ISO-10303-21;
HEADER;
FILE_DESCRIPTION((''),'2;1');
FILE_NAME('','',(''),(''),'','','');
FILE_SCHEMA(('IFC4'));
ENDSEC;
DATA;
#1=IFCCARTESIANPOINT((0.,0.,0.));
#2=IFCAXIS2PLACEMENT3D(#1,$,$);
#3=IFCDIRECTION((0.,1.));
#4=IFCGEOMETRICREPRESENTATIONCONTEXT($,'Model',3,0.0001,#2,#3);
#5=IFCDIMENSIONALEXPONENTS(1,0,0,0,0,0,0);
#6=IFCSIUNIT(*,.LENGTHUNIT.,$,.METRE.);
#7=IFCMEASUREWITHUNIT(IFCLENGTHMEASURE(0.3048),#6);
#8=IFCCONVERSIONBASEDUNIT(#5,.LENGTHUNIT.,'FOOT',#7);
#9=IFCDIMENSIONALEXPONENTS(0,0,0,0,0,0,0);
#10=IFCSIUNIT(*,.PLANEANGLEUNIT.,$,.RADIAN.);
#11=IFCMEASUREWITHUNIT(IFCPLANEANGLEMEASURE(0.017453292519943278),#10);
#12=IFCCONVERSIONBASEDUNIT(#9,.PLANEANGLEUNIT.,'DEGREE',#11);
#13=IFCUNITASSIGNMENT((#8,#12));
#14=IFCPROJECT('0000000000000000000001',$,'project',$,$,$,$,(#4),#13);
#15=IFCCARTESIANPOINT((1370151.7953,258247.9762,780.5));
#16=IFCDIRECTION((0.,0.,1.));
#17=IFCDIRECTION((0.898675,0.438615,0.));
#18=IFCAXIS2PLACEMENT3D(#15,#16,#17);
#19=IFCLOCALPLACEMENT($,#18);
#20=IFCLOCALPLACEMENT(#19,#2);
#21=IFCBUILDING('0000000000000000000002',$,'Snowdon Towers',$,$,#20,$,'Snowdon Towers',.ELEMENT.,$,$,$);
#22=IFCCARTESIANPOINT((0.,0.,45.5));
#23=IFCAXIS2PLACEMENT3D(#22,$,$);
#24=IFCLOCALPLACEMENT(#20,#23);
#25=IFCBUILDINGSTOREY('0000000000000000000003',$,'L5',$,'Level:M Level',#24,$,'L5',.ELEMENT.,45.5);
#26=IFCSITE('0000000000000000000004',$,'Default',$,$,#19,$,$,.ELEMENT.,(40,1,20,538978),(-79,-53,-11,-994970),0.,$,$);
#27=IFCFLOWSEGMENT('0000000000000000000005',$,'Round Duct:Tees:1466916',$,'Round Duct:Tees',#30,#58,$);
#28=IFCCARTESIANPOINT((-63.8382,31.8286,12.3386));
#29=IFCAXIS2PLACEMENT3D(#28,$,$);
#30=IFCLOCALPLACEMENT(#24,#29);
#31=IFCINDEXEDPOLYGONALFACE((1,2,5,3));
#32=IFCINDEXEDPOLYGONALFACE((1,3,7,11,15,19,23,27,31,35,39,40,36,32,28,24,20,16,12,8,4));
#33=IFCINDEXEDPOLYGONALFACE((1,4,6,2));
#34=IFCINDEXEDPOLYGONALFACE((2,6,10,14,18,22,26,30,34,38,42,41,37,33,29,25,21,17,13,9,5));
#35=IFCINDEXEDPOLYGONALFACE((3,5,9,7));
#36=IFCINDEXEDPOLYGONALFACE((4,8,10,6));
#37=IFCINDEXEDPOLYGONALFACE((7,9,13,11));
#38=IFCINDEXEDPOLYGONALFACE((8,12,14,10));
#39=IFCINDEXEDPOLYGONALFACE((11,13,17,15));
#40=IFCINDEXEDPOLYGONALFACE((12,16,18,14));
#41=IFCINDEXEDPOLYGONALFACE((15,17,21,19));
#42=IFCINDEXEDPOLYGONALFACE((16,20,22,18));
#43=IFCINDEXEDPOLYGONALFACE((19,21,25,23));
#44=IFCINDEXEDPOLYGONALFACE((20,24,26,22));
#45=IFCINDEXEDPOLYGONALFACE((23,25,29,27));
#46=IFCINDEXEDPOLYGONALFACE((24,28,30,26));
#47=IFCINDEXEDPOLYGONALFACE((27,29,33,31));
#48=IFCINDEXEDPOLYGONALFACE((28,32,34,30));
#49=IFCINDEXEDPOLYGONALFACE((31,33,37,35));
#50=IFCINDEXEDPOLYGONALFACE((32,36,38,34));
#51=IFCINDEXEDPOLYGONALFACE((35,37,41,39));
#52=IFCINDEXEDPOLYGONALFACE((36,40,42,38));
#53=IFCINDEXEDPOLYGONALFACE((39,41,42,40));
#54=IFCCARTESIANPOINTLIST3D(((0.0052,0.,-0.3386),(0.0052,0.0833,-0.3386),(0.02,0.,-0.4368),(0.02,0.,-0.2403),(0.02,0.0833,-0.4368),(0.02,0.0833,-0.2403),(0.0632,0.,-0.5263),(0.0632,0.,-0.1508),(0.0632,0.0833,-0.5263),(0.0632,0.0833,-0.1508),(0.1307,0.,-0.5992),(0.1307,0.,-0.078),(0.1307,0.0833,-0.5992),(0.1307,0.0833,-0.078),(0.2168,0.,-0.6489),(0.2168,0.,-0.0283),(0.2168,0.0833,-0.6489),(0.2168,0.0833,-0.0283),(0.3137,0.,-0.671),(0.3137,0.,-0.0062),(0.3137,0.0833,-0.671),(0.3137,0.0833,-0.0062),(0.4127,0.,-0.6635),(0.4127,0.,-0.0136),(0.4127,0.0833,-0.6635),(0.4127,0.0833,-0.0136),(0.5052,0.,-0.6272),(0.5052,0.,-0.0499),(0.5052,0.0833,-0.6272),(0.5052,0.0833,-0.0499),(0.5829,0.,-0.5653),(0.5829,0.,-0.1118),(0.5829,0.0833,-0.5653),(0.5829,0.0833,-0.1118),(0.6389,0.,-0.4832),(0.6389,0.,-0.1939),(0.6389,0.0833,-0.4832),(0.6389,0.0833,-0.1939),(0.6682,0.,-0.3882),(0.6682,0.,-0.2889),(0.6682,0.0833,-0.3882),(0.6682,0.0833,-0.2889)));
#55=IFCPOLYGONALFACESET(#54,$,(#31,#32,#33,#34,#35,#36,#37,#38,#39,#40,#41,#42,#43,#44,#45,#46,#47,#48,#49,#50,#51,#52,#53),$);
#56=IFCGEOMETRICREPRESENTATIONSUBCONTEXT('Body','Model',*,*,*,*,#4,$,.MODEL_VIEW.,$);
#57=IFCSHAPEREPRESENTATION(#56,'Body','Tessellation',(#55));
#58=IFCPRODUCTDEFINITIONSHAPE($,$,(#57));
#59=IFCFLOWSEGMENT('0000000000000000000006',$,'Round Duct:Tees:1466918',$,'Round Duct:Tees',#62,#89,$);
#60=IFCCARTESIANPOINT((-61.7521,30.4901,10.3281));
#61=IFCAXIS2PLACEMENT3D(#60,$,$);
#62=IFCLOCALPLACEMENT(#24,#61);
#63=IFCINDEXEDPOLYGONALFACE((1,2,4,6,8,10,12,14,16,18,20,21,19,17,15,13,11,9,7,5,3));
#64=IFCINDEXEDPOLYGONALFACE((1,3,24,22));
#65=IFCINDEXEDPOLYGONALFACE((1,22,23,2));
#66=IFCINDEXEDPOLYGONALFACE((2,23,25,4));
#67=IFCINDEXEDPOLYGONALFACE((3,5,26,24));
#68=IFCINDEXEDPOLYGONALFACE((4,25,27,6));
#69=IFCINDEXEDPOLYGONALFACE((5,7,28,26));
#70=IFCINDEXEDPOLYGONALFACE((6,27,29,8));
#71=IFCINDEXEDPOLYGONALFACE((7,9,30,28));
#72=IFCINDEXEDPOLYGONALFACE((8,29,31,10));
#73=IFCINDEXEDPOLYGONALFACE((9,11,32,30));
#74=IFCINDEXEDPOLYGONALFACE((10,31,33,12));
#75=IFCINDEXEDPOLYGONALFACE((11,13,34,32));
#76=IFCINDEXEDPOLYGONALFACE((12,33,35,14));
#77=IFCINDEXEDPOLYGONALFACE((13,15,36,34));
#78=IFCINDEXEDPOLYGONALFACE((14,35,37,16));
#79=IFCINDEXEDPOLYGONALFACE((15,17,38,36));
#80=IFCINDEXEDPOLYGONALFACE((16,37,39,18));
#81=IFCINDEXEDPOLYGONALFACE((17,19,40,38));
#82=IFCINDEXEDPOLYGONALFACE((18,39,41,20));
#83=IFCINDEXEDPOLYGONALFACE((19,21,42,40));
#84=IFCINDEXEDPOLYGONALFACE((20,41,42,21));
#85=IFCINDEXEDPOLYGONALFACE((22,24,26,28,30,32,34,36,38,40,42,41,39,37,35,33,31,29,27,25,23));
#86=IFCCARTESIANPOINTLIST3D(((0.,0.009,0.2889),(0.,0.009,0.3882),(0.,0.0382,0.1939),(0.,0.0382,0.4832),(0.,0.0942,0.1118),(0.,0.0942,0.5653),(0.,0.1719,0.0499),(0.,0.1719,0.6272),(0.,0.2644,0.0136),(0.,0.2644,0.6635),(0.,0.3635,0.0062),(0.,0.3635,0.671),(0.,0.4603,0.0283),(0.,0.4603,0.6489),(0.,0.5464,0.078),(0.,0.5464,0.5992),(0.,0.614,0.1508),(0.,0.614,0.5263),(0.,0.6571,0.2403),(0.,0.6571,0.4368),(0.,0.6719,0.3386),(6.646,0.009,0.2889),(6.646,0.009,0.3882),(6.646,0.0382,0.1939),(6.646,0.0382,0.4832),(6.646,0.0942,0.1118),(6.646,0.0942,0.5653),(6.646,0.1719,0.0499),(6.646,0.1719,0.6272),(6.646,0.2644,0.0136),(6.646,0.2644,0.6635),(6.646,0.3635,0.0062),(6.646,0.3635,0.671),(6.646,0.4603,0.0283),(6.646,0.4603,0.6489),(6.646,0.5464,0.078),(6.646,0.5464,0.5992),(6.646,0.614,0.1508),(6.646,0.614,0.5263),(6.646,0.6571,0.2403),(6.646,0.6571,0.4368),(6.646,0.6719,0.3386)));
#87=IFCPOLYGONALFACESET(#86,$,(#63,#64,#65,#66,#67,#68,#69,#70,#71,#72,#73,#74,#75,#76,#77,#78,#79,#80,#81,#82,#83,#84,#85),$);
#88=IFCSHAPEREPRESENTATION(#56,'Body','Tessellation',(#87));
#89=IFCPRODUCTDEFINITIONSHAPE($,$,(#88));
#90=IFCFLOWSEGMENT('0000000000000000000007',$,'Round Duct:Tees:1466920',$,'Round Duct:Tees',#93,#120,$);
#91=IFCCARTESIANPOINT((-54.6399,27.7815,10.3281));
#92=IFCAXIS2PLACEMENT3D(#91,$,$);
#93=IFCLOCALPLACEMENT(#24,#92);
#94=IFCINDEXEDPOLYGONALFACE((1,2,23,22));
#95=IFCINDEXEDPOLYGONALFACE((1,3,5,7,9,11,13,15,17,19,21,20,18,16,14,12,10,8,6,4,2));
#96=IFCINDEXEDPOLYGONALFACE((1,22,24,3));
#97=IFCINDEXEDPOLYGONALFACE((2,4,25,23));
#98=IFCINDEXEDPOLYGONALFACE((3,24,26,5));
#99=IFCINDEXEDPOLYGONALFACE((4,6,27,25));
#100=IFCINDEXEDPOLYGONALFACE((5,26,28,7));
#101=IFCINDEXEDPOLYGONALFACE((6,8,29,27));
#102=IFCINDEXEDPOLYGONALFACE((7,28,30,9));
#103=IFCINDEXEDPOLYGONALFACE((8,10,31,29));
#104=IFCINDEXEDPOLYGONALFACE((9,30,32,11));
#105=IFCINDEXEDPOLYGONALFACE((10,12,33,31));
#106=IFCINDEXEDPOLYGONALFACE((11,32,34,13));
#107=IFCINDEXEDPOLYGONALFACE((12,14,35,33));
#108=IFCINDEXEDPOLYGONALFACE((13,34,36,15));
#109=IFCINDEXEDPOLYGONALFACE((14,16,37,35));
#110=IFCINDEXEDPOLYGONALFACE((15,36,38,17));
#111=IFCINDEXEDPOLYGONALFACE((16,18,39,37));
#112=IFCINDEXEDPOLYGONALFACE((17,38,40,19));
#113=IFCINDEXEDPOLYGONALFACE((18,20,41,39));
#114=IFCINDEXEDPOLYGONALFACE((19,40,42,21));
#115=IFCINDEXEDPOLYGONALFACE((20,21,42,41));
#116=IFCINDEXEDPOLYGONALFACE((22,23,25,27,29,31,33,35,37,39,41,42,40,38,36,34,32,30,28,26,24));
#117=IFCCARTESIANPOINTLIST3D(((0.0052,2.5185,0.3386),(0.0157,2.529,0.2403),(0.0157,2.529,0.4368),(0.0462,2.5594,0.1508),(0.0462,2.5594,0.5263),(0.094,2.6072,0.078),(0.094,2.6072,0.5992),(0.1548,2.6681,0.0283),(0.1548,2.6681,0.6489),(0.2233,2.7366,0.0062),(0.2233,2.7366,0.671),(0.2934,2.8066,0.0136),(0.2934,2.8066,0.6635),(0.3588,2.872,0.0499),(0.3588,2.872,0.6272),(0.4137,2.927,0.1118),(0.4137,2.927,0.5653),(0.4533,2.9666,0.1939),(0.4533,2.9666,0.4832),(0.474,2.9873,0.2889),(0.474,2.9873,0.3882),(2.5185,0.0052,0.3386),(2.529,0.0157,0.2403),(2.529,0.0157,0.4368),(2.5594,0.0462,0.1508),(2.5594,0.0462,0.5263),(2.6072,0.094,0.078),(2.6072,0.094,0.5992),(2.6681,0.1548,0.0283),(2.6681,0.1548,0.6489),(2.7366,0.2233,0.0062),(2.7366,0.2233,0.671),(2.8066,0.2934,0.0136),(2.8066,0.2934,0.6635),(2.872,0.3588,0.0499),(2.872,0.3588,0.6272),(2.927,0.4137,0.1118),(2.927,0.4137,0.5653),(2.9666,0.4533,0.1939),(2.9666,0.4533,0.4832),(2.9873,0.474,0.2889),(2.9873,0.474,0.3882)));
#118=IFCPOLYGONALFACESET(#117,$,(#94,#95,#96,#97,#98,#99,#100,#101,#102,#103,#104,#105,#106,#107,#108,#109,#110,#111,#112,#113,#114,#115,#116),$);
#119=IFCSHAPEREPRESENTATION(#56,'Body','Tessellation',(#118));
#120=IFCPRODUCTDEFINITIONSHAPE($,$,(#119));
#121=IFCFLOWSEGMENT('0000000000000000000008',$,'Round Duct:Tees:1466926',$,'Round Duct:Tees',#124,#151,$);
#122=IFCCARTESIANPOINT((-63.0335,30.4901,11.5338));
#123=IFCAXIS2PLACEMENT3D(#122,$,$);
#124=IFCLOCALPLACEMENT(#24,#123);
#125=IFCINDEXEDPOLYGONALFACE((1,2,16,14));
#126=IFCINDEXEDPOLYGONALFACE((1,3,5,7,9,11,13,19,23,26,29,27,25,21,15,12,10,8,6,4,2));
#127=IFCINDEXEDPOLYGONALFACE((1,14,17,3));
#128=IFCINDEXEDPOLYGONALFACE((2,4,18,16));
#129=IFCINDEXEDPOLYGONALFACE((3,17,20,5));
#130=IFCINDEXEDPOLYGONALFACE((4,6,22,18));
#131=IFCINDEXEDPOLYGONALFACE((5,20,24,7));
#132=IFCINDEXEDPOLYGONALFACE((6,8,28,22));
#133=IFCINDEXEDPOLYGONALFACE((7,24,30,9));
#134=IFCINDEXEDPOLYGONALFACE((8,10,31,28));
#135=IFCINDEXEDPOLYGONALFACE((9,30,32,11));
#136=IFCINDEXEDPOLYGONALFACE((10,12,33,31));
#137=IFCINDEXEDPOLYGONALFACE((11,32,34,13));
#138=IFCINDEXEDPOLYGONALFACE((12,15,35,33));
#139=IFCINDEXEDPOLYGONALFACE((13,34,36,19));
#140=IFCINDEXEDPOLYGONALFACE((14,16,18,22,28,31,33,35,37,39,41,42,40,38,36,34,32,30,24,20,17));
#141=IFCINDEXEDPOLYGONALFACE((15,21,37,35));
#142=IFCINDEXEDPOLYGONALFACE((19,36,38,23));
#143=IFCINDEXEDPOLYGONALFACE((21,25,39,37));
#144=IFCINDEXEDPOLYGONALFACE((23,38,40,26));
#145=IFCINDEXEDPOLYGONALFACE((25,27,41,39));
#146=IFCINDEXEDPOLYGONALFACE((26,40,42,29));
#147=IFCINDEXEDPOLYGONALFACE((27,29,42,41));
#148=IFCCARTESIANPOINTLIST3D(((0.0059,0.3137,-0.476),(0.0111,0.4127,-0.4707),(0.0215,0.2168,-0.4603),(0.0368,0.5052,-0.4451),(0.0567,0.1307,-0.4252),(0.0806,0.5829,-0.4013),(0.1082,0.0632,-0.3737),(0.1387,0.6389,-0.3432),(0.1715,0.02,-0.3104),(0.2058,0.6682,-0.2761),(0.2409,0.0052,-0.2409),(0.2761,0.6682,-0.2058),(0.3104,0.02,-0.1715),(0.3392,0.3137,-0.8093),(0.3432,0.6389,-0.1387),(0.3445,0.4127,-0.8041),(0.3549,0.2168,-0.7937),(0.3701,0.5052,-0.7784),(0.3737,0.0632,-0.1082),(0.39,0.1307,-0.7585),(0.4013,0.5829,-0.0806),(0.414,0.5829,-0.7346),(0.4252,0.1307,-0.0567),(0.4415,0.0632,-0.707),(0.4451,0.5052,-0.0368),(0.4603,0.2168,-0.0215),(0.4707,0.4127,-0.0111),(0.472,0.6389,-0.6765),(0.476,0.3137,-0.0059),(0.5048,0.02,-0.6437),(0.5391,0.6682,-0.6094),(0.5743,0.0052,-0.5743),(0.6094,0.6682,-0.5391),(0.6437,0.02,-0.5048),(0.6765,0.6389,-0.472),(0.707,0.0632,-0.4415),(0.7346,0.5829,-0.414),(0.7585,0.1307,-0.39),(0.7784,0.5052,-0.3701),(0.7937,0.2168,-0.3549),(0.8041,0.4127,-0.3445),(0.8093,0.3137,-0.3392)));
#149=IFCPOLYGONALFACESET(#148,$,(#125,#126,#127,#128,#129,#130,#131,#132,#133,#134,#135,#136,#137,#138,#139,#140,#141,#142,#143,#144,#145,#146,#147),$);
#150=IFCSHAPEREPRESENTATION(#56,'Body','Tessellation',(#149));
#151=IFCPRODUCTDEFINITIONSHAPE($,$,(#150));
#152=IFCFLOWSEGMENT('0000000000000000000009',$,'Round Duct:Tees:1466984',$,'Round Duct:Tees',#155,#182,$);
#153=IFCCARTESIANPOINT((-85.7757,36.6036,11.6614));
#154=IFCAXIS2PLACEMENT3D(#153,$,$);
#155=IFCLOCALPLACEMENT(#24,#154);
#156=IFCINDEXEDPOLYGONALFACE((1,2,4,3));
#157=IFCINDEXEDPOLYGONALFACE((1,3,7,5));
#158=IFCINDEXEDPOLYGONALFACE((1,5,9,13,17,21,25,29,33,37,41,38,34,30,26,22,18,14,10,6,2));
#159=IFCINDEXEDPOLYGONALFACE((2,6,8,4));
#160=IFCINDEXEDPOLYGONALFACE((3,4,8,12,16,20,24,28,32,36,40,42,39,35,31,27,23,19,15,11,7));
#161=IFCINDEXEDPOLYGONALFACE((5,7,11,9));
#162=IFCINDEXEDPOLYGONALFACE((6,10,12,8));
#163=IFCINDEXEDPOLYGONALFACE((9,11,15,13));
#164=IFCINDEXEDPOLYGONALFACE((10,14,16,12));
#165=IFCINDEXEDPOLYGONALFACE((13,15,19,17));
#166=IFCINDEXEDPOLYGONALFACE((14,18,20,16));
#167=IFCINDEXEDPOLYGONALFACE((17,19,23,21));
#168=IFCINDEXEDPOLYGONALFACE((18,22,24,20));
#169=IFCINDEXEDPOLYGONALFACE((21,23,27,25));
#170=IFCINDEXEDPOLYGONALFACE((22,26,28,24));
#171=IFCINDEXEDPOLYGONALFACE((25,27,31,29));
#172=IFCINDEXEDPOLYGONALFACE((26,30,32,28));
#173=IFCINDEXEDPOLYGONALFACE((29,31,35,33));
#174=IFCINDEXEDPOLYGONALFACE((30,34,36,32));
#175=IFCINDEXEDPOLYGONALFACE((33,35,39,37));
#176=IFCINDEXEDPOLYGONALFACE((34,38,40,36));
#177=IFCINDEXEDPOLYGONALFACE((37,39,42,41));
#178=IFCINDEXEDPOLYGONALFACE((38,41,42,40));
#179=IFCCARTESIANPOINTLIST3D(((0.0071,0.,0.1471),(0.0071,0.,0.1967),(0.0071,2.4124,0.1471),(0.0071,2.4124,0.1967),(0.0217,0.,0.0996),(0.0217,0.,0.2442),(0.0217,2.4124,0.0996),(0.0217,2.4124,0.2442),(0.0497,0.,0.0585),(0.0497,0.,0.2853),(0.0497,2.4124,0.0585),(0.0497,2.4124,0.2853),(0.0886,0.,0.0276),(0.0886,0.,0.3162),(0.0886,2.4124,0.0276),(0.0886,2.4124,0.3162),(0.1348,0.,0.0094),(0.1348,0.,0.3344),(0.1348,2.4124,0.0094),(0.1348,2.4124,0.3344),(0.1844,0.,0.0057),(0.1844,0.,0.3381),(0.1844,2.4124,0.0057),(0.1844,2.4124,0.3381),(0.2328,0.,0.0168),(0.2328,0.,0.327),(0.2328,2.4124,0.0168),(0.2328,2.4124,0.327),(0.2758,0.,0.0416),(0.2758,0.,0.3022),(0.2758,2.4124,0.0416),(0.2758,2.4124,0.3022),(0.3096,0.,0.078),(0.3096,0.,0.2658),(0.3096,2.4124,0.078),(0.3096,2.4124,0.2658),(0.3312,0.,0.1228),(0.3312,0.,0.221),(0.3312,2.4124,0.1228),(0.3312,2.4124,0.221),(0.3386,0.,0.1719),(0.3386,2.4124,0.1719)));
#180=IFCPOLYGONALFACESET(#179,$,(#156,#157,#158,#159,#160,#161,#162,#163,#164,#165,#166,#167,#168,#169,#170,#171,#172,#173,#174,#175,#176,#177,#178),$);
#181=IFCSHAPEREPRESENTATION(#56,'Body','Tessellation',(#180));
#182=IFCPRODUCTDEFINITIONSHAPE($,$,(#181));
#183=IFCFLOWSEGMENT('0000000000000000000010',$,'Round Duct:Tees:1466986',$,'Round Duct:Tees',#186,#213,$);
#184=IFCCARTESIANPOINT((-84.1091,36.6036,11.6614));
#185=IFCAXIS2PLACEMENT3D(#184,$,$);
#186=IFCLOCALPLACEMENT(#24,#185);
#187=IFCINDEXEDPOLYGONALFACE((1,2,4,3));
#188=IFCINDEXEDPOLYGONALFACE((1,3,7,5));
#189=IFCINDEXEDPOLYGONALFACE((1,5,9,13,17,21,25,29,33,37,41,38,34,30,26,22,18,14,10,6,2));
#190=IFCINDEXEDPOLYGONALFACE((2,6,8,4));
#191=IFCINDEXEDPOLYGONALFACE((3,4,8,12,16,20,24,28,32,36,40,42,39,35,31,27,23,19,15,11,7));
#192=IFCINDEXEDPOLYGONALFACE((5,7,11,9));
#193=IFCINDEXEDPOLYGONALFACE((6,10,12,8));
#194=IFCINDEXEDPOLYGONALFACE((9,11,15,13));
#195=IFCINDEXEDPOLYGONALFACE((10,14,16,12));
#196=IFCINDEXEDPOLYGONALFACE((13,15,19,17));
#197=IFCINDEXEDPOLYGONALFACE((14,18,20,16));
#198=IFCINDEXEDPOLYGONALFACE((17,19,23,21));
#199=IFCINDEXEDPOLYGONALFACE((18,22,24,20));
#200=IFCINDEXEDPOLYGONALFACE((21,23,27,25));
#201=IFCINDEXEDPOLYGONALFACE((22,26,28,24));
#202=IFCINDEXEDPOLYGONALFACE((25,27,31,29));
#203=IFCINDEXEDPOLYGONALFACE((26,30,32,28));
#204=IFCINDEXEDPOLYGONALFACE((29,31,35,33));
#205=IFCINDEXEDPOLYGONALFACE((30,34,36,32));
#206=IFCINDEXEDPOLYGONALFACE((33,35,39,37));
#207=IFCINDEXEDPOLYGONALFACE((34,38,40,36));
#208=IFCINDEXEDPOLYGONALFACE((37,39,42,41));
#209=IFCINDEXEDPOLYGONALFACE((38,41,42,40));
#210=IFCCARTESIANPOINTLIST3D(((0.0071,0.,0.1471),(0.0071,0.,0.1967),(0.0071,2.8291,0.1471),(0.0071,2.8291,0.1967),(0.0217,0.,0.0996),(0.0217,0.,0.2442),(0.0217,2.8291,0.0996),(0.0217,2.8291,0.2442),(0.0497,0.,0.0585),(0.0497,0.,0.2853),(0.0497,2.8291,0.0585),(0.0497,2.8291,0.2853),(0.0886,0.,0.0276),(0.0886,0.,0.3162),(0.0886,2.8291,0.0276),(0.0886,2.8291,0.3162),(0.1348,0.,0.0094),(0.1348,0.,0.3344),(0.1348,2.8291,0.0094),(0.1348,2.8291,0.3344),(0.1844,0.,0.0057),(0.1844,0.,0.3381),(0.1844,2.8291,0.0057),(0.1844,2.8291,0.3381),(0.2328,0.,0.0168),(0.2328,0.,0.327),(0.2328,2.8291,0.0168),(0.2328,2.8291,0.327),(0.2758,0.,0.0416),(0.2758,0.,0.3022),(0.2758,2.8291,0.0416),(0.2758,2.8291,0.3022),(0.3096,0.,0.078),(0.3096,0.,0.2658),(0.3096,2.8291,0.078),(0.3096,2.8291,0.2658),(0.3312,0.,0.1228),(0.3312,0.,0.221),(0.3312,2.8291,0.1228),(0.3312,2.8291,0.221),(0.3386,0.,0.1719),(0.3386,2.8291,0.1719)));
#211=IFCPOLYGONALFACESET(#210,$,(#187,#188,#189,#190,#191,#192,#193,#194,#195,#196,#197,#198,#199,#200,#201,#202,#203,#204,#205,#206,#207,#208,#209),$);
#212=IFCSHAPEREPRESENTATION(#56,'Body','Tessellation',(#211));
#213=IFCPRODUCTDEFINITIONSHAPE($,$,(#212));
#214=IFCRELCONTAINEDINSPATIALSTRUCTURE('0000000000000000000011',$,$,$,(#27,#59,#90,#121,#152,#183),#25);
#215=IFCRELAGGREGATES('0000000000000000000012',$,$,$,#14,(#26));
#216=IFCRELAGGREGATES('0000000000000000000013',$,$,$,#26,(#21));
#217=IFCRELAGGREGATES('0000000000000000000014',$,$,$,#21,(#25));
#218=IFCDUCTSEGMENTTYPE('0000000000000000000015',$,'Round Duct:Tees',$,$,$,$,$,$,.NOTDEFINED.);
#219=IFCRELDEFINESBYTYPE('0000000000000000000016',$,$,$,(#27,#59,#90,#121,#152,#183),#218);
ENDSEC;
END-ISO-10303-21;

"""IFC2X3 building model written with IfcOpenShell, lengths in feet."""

from ifc_helpers import new_model, entity, si_unit, converted_unit, direction, frame, frame_2d, origin, origin_2d_with_axis, place, context, subcontext, project, spatial, circle, extrude, type_object, element, save


model = new_model("IFC2X3")

# Units and contexts
model_context = context("Model", 3, precision=0.0001, world=origin(), true_north=direction((0.0, 1.0)))
body_context = subcontext(model_context, "Body", "Model", "MODEL_VIEW")
ifc_project = project(units=[converted_unit("LENGTHUNIT", "FOOT", entity("IfcLengthMeasure", 0.3048), si_unit("LENGTHUNIT", "METRE"), dimensions=[1, 0, 0, 0, 0, 0, 0]), converted_unit("PLANEANGLEUNIT", "DEGREE", entity("IfcPlaneAngleMeasure", 0.017453292519943278), si_unit("PLANEANGLEUNIT", "RADIAN"), dimensions=[0, 0, 0, 0, 0, 0, 0])], contexts=[model_context])

# Site, building, storey
site_placement = place(None, frame((1370151.7953, 258247.9762, 780.5), z_axis=(0.0, 0.0, 1.0), x_axis=(0.898675, 0.438615, 0.0)))
site = spatial("IfcSite", under=ifc_project, at=site_placement, Name="Default", CompositionType="ELEMENT", RefLatitude=(40, 1, 20, 538978), RefLongitude=(-79, -53, -11, -994970), RefElevation=0.0)
building_placement = place(site_placement, origin())
building = spatial("IfcBuilding", under=site, at=building_placement, Name="Snowdon Towers", LongName="Snowdon Towers", CompositionType="ELEMENT")
storey_placement = place(building_placement, frame((0.0, 0.0, 45.5)))
storey = spatial("IfcBuildingStorey", under=building, at=storey_placement, Name="L5", ObjectType="Level:M Level", LongName="L5", CompositionType="ELEMENT", Elevation=45.5)

# Flow segments
duct_segment_type = type_object("IfcDuctSegmentType", Name="Round Duct:Tees", PredefinedType="NOTDEFINED")
flow_segment_1_placement = place(storey_placement, frame((-63.8382, 31.8286, 12.3386)))
element("IfcFlowSegment", 1, at=flow_segment_1_placement, inside=storey, type_object=duct_segment_type, Name="Round Duct:Tees:1466916", ObjectType="Round Duct:Tees", context=body_context, shape_type="SweptSolid", body=[
    extrude(circle(Radius=0.3333, at=frame_2d((0.0, 0.0), x_axis=(1.0, 0.0))), frame((0.3386, 0.0, -0.3386), z_axis=(0.0, 1.0, 0.0), x_axis=(-1.0, 0.0, 0.0)), (0.0, 0.0, 1.0), 0.0833),
])
flow_segment_2_placement = place(storey_placement, frame((-61.7521, 30.4901, 10.3281)))
element("IfcFlowSegment", 2, at=flow_segment_2_placement, inside=storey, type_object=duct_segment_type, Name="Round Duct:Tees:1466918", ObjectType="Round Duct:Tees", context=body_context, shape_type="SweptSolid", body=[
    extrude(circle(Radius=0.3333, at=origin_2d_with_axis()), frame((0.0, 0.3386, 0.3386), z_axis=(1.0, 0.0, 0.0), x_axis=(0.0, 1.0, 0.0)), (0.0, 0.0, 1.0), 6.646),
])
flow_segment_3_placement = place(storey_placement, frame((-54.6399, 27.7815, 10.3281)))
element("IfcFlowSegment", 3, at=flow_segment_3_placement, inside=storey, type_object=duct_segment_type, Name="Round Duct:Tees:1466920", ObjectType="Round Duct:Tees", context=body_context, shape_type="SweptSolid", body=[
    extrude(circle(Radius=0.3333, at=frame_2d((0.0, 0.0), x_axis=(1.0, 0.0))), frame((2.7542, 0.2409, 0.3386), z_axis=(-0.707107, 0.707107, 0.0), x_axis=(-0.707107, -0.707107, 0.0)), (0.0, 0.0, 1.0), 3.5543),
])
flow_segment_4_placement = place(storey_placement, frame((-63.0335, 30.4901, 11.5338)))
element("IfcFlowSegment", 4, at=flow_segment_4_placement, inside=storey, type_object=duct_segment_type, Name="Round Duct:Tees:1466926", ObjectType="Round Duct:Tees", context=body_context, shape_type="SweptSolid", body=[
    extrude(circle(Radius=0.3333, at=frame_2d((0.0, 0.0), x_axis=(1.0, 0.0))), frame((0.5743, 0.3386, -0.5743), z_axis=(-0.707107, 0.0, 0.707107), x_axis=(0.0, -1.0, 0.0)), (0.0, 0.0, 1.0), 0.4714),
])
flow_segment_5_placement = place(storey_placement, frame((-85.7757, 36.6036, 11.6614)))
element("IfcFlowSegment", 5, at=flow_segment_5_placement, inside=storey, type_object=duct_segment_type, Name="Round Duct:Tees:1466984", ObjectType="Round Duct:Tees", context=body_context, shape_type="SweptSolid", body=[
    extrude(circle(Radius=0.1667, at=frame_2d((0.0, 0.0), x_axis=(1.0, 0.0))), frame((0.1719, 0.0, 0.1719), z_axis=(0.0, 1.0, 0.0), x_axis=(1.0, 0.0, 0.0)), (0.0, 0.0, 1.0), 2.4124),
])
flow_segment_6_placement = place(storey_placement, frame((-84.1091, 36.6036, 11.6614)))
element("IfcFlowSegment", 6, at=flow_segment_6_placement, inside=storey, type_object=duct_segment_type, Name="Round Duct:Tees:1466986", ObjectType="Round Duct:Tees", context=body_context, shape_type="SweptSolid", body=[
    extrude(circle(Radius=0.1667, at=frame_2d((0.0, 0.0), x_axis=(1.0, 0.0))), frame((0.1719, 0.0, 0.1719), z_axis=(0.0, 1.0, 0.0), x_axis=(1.0, 0.0, 0.0)), (0.0, 0.0, 1.0), 2.8291),
])

save(model, "model.ifc")
